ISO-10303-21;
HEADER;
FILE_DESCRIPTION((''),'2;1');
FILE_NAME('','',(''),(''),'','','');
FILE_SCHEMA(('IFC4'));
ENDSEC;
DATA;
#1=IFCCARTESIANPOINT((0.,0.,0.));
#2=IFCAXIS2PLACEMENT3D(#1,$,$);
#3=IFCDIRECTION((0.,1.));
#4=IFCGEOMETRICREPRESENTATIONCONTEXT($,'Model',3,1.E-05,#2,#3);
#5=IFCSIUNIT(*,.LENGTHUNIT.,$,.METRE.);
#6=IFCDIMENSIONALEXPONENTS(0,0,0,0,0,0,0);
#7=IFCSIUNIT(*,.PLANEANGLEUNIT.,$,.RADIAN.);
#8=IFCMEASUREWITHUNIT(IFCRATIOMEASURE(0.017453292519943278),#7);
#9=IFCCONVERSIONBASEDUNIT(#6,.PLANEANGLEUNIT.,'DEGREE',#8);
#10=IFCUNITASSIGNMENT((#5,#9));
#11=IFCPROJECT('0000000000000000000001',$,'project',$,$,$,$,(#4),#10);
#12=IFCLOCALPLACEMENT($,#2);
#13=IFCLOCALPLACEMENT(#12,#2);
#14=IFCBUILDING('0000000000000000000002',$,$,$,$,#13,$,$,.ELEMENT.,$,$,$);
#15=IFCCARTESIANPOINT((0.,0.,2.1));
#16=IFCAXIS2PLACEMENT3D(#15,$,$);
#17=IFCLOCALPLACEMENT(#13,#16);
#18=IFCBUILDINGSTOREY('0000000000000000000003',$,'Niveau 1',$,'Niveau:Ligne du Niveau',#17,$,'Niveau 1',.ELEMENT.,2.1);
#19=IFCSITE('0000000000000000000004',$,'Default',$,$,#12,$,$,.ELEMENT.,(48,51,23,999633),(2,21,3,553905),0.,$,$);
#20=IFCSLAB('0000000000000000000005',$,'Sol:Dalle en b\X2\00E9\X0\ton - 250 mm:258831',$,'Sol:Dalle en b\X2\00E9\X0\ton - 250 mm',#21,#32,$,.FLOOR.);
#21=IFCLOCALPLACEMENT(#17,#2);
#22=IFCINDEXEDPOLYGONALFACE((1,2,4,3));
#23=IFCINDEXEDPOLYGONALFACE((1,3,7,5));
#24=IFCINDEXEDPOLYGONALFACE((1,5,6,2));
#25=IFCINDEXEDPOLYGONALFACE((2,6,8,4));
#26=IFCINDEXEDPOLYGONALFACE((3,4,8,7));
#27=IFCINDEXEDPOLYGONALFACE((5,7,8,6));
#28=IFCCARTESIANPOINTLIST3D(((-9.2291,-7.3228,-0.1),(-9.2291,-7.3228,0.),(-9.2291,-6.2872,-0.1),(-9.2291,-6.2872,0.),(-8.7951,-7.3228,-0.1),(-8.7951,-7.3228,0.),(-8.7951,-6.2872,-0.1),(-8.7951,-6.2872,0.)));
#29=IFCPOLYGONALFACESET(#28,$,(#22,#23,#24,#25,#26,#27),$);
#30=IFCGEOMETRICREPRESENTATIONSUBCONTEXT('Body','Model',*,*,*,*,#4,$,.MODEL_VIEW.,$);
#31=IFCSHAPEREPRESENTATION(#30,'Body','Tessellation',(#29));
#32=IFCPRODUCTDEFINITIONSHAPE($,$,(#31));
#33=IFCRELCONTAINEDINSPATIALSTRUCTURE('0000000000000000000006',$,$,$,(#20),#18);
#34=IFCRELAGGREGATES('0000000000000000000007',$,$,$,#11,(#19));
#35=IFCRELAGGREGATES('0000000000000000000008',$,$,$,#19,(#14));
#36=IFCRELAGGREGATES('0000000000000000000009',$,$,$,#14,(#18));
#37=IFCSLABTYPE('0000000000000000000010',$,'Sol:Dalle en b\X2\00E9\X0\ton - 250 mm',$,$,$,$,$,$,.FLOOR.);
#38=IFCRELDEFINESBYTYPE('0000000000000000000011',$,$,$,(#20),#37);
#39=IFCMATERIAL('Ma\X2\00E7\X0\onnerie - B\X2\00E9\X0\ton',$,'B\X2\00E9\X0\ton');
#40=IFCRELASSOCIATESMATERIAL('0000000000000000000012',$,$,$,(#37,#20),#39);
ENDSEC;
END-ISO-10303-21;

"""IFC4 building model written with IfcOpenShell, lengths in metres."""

from ifc_helpers import new_model, entity, si_unit, converted_unit, direction, frame, origin, place, context, subcontext, project, spatial, indexed_curve, outline, extrude, material, type_object, element, save


model = new_model("IFC4")

# Units and contexts
model_context = context("Model", 3, precision=1e-05, world=origin(), true_north=direction((0.0, 1.0)))
body_context = subcontext(model_context, "Body", "Model", "MODEL_VIEW")
ifc_project = project(units=[si_unit("LENGTHUNIT", "METRE"), converted_unit("PLANEANGLEUNIT", "DEGREE", entity("IfcRatioMeasure", 0.017453292519943278), si_unit("PLANEANGLEUNIT", "RADIAN"), dimensions=[0, 0, 0, 0, 0, 0, 0])], contexts=[model_context])

# Site, building, storey
site_placement = place(None, origin())
site = spatial("IfcSite", under=ifc_project, at=site_placement, Name="Default", CompositionType="ELEMENT", RefLatitude=(48, 51, 23, 999633), RefLongitude=(2, 21, 3, 553905), RefElevation=0.0)
building_placement = place(site_placement, origin())
building = spatial("IfcBuilding", under=site, at=building_placement, CompositionType="ELEMENT")
storey_placement = place(building_placement, frame((0.0, 0.0, 2.1)))
storey = spatial("IfcBuildingStorey", under=building, at=storey_placement, Name="Niveau 1", ObjectType="Niveau:Ligne du Niveau", LongName="Niveau 1", CompositionType="ELEMENT", Elevation=2.1)

# Slab
ifc_material = material(Name="Maçonnerie - Béton", Category="Béton")
slab_type_1 = type_object("IfcSlabType", Name="Sol:Dalle en béton - 250 mm", PredefinedType="FLOOR", material=ifc_material)
slab_1_placement = place(storey_placement, origin())
element("IfcSlab", 1, at=slab_1_placement, inside=storey, type_object=slab_type_1, material=ifc_material, Name="Sol:Dalle en béton - 250 mm:258831", ObjectType="Sol:Dalle en béton - 250 mm", PredefinedType="FLOOR", context=body_context, shape_type="SweptSolid", body=[
    extrude(outline(indexed_curve([(-0.5178, -0.217), (0.5178, -0.217), (0.5178, 0.217), (-0.5178, 0.217), (-0.5178, -0.217)], self_intersect=False)), frame((-9.0121, -6.805, 0.0), z_axis=(0.0, 0.0, -1.0), x_axis=(0.0, 1.0, 0.0)), (0.0, 0.0, 1.0), 0.1),
])

save(model, "model.ifc")
